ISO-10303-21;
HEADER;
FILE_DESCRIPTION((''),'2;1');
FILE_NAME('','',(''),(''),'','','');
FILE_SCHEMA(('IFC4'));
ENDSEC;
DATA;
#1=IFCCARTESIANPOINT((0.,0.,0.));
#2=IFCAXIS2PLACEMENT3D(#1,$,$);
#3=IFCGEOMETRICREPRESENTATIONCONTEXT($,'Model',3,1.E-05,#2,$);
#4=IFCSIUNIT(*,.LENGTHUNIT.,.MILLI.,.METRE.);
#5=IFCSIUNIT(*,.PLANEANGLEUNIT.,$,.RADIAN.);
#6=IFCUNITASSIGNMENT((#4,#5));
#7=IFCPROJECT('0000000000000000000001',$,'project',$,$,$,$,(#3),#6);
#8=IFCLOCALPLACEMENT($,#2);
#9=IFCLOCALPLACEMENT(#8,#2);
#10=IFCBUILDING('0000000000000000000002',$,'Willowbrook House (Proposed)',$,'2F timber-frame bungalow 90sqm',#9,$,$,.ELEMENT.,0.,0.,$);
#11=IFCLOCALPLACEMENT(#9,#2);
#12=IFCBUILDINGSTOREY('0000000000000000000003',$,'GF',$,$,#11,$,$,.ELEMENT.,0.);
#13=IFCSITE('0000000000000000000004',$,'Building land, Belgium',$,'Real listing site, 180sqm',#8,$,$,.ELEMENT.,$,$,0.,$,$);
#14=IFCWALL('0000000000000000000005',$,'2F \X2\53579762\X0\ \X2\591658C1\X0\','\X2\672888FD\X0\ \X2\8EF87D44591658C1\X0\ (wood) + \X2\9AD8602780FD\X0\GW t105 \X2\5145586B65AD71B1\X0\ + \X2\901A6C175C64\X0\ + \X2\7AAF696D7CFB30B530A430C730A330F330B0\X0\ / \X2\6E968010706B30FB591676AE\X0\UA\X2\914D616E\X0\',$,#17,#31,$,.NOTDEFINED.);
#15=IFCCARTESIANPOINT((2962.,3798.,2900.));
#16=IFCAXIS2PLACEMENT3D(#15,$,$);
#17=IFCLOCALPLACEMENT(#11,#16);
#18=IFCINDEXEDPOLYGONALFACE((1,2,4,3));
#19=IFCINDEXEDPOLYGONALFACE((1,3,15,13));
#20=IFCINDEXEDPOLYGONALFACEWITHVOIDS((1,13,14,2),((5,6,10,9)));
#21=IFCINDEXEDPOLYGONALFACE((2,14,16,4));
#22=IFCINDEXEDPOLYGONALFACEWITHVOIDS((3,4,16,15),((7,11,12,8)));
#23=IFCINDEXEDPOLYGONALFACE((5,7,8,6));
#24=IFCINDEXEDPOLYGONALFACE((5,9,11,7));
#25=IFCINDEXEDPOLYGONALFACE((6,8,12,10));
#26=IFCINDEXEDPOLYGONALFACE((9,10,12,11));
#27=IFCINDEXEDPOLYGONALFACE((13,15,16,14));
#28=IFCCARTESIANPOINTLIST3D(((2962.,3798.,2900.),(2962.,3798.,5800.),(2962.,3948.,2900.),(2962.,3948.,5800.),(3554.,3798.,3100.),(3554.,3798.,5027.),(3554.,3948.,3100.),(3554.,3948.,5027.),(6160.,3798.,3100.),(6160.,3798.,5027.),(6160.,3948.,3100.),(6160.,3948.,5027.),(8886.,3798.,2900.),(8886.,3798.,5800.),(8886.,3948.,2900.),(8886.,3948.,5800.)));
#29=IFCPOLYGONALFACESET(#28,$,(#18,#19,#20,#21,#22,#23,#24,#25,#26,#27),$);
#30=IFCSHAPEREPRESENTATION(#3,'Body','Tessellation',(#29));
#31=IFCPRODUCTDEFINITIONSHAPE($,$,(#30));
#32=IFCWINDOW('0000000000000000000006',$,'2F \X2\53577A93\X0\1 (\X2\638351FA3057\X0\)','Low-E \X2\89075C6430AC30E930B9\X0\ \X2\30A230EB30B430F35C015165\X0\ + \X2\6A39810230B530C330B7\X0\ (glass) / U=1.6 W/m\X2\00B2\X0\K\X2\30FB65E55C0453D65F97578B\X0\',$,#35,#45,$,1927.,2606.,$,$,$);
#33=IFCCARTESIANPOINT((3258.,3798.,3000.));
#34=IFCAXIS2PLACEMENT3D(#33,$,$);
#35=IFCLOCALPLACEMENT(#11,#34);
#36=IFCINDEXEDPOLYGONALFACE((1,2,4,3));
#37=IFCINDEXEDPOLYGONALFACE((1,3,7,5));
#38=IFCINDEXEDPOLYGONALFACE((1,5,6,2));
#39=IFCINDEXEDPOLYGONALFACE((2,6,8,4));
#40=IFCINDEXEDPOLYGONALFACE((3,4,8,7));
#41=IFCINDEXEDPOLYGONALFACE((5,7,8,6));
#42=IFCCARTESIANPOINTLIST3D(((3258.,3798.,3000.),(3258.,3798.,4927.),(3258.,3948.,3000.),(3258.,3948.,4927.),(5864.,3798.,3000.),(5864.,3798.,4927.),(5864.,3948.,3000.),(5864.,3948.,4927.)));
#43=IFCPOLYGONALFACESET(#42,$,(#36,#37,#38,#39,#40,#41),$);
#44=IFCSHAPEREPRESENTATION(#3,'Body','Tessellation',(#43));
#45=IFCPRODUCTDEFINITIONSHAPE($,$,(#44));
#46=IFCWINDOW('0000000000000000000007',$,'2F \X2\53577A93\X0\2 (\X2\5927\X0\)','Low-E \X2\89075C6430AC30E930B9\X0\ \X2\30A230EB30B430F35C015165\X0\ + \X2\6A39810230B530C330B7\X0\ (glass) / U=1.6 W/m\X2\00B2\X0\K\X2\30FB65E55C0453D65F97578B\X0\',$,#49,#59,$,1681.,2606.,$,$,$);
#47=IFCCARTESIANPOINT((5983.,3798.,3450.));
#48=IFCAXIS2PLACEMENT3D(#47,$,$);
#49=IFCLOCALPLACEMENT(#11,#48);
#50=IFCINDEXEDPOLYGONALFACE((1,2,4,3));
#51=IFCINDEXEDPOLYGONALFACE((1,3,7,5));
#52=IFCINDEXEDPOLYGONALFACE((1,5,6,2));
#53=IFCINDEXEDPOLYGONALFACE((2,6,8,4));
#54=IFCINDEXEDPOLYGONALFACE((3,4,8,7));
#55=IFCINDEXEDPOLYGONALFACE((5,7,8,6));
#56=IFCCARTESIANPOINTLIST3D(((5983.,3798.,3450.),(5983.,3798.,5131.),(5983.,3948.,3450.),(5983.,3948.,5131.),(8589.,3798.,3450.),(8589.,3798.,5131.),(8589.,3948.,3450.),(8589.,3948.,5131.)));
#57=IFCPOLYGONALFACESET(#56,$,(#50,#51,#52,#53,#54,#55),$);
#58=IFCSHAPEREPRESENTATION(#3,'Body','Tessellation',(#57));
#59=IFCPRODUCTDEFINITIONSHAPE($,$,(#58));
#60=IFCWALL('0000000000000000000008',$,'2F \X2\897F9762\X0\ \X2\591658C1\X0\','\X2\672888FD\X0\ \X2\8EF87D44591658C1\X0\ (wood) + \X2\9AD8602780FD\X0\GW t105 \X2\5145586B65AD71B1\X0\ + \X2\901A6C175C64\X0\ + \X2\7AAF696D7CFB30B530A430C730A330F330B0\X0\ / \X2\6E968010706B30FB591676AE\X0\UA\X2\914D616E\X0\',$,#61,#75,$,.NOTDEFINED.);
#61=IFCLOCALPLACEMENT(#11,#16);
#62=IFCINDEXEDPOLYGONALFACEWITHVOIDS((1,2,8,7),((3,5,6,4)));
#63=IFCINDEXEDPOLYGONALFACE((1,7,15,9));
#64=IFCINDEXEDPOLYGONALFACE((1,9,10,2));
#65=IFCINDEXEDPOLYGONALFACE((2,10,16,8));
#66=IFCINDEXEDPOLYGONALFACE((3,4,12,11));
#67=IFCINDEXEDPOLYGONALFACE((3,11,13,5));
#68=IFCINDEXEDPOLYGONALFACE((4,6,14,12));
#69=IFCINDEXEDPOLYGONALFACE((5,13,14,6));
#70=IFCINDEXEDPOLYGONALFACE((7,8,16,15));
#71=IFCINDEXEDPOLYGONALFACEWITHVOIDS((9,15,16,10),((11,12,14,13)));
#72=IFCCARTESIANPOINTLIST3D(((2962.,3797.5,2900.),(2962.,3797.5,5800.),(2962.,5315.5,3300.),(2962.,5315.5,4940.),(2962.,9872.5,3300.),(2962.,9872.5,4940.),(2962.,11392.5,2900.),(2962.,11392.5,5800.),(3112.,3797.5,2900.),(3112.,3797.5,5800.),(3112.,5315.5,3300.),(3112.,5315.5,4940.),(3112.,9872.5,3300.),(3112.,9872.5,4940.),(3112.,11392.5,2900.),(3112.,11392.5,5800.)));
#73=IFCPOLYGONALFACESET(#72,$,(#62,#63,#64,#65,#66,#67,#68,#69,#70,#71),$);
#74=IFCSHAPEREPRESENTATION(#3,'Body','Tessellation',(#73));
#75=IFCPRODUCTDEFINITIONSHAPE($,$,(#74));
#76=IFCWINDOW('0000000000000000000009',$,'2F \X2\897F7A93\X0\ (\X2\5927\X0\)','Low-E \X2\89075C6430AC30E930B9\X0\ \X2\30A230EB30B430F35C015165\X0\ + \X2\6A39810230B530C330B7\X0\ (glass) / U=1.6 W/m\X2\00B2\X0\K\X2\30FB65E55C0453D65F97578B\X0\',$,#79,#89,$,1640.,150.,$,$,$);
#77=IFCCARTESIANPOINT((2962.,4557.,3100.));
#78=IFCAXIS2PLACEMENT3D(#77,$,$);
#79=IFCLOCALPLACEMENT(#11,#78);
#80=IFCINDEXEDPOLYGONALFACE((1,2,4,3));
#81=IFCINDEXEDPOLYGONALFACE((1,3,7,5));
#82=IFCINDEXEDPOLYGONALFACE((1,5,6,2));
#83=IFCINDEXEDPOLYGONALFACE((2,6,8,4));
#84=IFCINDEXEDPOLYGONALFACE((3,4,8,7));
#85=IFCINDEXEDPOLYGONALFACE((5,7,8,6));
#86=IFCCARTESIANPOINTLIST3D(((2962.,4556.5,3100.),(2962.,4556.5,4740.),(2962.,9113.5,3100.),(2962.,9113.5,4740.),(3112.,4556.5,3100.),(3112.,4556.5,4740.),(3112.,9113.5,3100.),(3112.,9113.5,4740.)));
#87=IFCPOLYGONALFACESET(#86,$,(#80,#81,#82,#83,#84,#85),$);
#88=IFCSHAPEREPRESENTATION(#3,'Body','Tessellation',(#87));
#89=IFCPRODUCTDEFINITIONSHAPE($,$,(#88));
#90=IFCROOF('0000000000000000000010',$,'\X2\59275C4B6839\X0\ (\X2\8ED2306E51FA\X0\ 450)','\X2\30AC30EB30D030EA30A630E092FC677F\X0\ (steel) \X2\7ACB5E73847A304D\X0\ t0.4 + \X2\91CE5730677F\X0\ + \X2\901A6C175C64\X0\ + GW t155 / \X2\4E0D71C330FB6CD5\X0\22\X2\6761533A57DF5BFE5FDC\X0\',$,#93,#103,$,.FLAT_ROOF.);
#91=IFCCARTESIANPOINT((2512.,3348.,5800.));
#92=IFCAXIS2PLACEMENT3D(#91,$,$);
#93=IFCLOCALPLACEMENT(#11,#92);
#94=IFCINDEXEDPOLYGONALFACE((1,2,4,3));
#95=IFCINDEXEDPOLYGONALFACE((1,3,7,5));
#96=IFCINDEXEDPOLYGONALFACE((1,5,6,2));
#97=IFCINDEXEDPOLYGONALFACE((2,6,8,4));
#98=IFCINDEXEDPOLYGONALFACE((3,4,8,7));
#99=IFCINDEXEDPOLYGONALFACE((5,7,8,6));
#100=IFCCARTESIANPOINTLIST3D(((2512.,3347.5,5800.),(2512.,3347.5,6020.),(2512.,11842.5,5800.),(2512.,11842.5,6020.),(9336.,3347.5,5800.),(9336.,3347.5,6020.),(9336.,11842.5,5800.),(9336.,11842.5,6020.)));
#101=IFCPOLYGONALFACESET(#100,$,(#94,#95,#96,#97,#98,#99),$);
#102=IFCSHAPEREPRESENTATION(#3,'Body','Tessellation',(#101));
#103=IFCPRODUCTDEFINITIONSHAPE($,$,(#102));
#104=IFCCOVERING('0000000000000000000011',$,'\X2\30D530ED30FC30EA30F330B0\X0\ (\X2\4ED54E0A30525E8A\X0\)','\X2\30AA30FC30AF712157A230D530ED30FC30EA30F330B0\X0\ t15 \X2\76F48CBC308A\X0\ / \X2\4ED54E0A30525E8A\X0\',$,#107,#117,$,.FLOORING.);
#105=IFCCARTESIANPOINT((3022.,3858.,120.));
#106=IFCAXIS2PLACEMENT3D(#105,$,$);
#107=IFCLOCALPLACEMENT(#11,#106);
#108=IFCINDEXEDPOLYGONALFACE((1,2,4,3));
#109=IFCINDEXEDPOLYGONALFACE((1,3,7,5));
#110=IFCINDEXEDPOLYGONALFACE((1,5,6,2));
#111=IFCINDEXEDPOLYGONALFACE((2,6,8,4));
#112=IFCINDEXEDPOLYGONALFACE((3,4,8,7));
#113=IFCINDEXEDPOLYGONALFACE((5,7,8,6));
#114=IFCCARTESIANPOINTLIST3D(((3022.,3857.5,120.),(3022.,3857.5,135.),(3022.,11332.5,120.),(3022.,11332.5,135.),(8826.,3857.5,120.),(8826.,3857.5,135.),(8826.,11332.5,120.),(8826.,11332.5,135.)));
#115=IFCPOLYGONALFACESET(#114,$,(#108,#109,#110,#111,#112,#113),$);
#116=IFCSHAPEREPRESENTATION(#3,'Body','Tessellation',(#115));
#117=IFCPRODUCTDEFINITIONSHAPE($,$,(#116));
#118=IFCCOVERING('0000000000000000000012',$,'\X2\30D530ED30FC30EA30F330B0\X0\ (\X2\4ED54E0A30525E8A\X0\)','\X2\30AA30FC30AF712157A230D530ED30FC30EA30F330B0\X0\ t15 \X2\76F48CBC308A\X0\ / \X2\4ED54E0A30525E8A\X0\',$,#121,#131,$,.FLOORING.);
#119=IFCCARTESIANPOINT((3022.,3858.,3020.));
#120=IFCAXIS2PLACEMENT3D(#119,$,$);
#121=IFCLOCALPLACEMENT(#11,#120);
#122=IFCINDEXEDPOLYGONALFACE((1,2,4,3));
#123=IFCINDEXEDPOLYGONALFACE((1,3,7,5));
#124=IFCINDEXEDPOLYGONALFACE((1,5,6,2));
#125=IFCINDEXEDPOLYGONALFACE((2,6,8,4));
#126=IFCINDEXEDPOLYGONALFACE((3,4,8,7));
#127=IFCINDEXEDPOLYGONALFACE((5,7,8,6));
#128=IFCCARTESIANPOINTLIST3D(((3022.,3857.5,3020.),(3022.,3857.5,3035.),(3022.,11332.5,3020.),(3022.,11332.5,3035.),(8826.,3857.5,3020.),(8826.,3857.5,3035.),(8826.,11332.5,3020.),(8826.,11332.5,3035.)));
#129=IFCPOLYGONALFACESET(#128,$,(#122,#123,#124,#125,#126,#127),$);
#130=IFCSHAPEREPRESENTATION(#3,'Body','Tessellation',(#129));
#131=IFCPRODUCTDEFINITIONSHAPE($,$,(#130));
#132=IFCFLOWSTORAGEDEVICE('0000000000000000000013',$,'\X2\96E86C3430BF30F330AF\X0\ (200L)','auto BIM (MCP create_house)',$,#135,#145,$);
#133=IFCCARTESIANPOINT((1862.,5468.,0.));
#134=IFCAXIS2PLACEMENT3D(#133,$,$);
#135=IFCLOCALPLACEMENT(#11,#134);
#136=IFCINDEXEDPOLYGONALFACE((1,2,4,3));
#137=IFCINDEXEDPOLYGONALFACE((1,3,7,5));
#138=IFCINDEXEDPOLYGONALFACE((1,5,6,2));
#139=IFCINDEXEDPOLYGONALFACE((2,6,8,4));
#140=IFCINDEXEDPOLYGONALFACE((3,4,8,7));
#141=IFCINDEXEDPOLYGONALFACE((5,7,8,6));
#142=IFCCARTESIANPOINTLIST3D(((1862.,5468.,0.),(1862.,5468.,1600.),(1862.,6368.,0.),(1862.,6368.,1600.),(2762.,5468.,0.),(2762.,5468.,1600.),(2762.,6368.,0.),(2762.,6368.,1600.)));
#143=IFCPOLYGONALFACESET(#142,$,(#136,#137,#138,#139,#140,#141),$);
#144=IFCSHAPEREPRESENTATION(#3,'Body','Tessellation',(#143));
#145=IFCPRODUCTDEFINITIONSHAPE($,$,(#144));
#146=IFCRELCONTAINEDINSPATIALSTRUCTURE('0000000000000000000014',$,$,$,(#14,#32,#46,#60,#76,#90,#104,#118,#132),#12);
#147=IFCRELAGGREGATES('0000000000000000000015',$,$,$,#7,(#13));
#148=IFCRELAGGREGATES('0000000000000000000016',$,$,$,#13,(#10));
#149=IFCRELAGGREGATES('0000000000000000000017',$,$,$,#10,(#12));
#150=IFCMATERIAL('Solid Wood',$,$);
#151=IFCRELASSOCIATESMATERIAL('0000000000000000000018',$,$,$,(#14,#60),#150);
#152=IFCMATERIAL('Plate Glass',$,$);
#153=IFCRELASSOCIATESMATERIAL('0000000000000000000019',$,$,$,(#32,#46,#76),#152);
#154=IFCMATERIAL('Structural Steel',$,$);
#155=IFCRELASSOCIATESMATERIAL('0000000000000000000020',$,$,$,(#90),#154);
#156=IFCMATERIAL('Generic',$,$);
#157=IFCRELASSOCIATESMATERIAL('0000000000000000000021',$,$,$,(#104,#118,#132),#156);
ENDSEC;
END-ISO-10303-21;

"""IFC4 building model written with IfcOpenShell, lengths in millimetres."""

from ifc_helpers import new_model, si_unit, frame, frame_2d, origin, place, context, project, spatial, rectangle, extrude, material, element, fill, save


model = new_model("IFC4")

# Units and contexts
model_context = context("Model", 3, precision=1e-05, world=origin())
ifc_project = project(units=[si_unit("LENGTHUNIT", "METRE", prefix="MILLI"), si_unit("PLANEANGLEUNIT", "RADIAN")], contexts=[model_context])

# Site, building, storey
site_placement = place(None, origin())
site = spatial("IfcSite", under=ifc_project, at=site_placement, Name="Building land, Belgium", ObjectType="Real listing site, 180sqm", CompositionType="ELEMENT", RefElevation=0.0)
building_placement = place(site_placement, origin())
building = spatial("IfcBuilding", under=site, at=building_placement, Name="Willowbrook House (Proposed)", ObjectType="2F timber-frame bungalow 90sqm", CompositionType="ELEMENT", ElevationOfRefHeight=0.0, ElevationOfTerrain=0.0)
storey_placement = place(building_placement, origin())
storey = spatial("IfcBuildingStorey", under=building, at=storey_placement, Name="GF", CompositionType="ELEMENT", Elevation=0.0)

# Shared definitions
ifc_material_1 = material(Name="Solid Wood")

# Shared definitions
ifc_material_2 = material(Name="Plate Glass")

# Wall, openings, windows
wall_1_placement = place(storey_placement, frame((2962.0, 3798.0, 2900.0)))
wall_1 = element("IfcWall", 1, at=wall_1_placement, inside=storey, material=ifc_material_1, Name="2F 南面 外壁", Description="木製 軸組外壁 (wood) + 高性能GW t105 充填断熱 + 通気層 + 窯業系サイディング / 準耐火・外皮UA配慮", PredefinedType="NOTDEFINED", context=model_context, shape_type="SweptSolid", body=[
    extrude(rectangle(XDim=5924.0, YDim=150.0, at=frame_2d((2962.0, 75.0))), frame((2962.0, 3798.0, 2900.0)), (0.0, 0.0, 1.0), 2900.0),
])
opening_1_placement = place(storey_placement, frame((3258.0, 3798.0, 3000.0)))
opening_1 = element("IfcOpeningElement", 2, at=opening_1_placement, cuts=wall_1, PredefinedType="NOTDEFINED", context=model_context, shape_type="SweptSolid", body=[
    extrude(rectangle(XDim=2606.0, YDim=150.0, at=frame_2d((1303.0, 75.0))), frame((3258.0, 3798.0, 3000.0)), (0.0, 0.0, 1.0), 1927.0),
])
opening_2_placement = place(storey_placement, frame((5983.0, 3798.0, 3450.0)))
opening_2 = element("IfcOpeningElement", 3, at=opening_2_placement, cuts=wall_1, PredefinedType="NOTDEFINED", context=model_context, shape_type="SweptSolid", body=[
    extrude(rectangle(XDim=2606.0, YDim=150.0, at=frame_2d((1303.0, 75.0))), frame((5983.0, 3798.0, 3450.0)), (0.0, 0.0, 1.0), 1681.0),
])
window_1_placement = place(storey_placement, frame((3258.0, 3798.0, 3000.0)))
window_1 = element("IfcWindow", 4, at=window_1_placement, inside=storey, material=ifc_material_2, Name="2F 南窓1 (掃出し)", Description="Low-E 複層ガラス アルゴン封入 + 樹脂サッシ (glass) / U=1.6 W/m²K・日射取得型", OverallHeight=1927.0, OverallWidth=2606.0, context=model_context, shape_type="SweptSolid", body=[
    extrude(rectangle(XDim=2606.0, YDim=150.0, at=frame_2d((1303.0, 75.0))), frame((3258.0, 3798.0, 3000.0)), (0.0, 0.0, 1.0), 1927.0),
])
fill(opening_1, window_1)
window_2_placement = place(storey_placement, frame((5983.0, 3798.0, 3450.0)))
window_2 = element("IfcWindow", 5, at=window_2_placement, inside=storey, material=ifc_material_2, Name="2F 南窓2 (大)", Description="Low-E 複層ガラス アルゴン封入 + 樹脂サッシ (glass) / U=1.6 W/m²K・日射取得型", OverallHeight=1681.0, OverallWidth=2606.0, context=model_context, shape_type="SweptSolid", body=[
    extrude(rectangle(XDim=2606.0, YDim=150.0, at=frame_2d((1303.0, 75.0))), frame((5983.0, 3798.0, 3450.0)), (0.0, 0.0, 1.0), 1681.0),
])
fill(opening_2, window_2)

# Wall, opening, window
wall_2_placement = place(storey_placement, frame((2962.0, 3798.0, 2900.0)))
wall_2 = element("IfcWall", 6, at=wall_2_placement, inside=storey, material=ifc_material_1, Name="2F 西面 外壁", Description="木製 軸組外壁 (wood) + 高性能GW t105 充填断熱 + 通気層 + 窯業系サイディング / 準耐火・外皮UA配慮", PredefinedType="NOTDEFINED", context=model_context, shape_type="SweptSolid", body=[
    extrude(rectangle(XDim=150.0, YDim=7595.0, at=frame_2d((75.0, 3797.0))), frame((2962.0, 3798.0, 2900.0)), (0.0, 0.0, 1.0), 2900.0),
])
opening_3_placement = place(storey_placement, frame((2962.0, 4557.0, 3100.0)))
opening_3 = element("IfcOpeningElement", 7, at=opening_3_placement, cuts=wall_2, PredefinedType="NOTDEFINED", context=model_context, shape_type="SweptSolid", body=[
    extrude(rectangle(XDim=150.0, YDim=4557.0, at=frame_2d((75.0, 2278.0))), frame((2962.0, 4557.0, 3100.0)), (0.0, 0.0, 1.0), 1640.0),
])
window_3_placement = place(storey_placement, frame((2962.0, 4557.0, 3100.0)))
window_3 = element("IfcWindow", 8, at=window_3_placement, inside=storey, material=ifc_material_2, Name="2F 西窓 (大)", Description="Low-E 複層ガラス アルゴン封入 + 樹脂サッシ (glass) / U=1.6 W/m²K・日射取得型", OverallHeight=1640.0, OverallWidth=150.0, context=model_context, shape_type="SweptSolid", body=[
    extrude(rectangle(XDim=150.0, YDim=4557.0, at=frame_2d((75.0, 2278.0))), frame((2962.0, 4557.0, 3100.0)), (0.0, 0.0, 1.0), 1640.0),
])
fill(opening_3, window_3)

# Roof
ifc_material_3 = material(Name="Structural Steel")
roof_placement = place(storey_placement, frame((2512.0, 3348.0, 5800.0)))
element("IfcRoof", 9, at=roof_placement, inside=storey, material=ifc_material_3, Name="大屋根 (軒の出 450)", Description="ガルバリウム鋼板 (steel) 立平葺き t0.4 + 野地板 + 通気層 + GW t155 / 不燃・法22条区域対応", PredefinedType="FLAT_ROOF", context=model_context, shape_type="SweptSolid", body=[
    extrude(rectangle(XDim=6824.0, YDim=8495.0, at=frame_2d((3412.0, 4247.0))), frame((2512.0, 3348.0, 5800.0)), (0.0, 0.0, 1.0), 220.0),
])

# Coverings
ifc_material_4 = material(Name="Generic")
covering_1_placement = place(storey_placement, frame((3022.0, 3858.0, 120.0)))
element("IfcCovering", 10, at=covering_1_placement, inside=storey, material=ifc_material_4, Name="フローリング (仕上げ床)", Description="オーク無垢フローリング t15 直貼り / 仕上げ床", PredefinedType="FLOORING", context=model_context, shape_type="SweptSolid", body=[
    extrude(rectangle(XDim=5804.0, YDim=7475.0, at=frame_2d((2902.0, 3737.0))), frame((3022.0, 3858.0, 120.0)), (0.0, 0.0, 1.0), 15.0),
])
covering_2_placement = place(storey_placement, frame((3022.0, 3858.0, 3020.0)))
element("IfcCovering", 11, at=covering_2_placement, inside=storey, material=ifc_material_4, Name="フローリング (仕上げ床)", Description="オーク無垢フローリング t15 直貼り / 仕上げ床", PredefinedType="FLOORING", context=model_context, shape_type="SweptSolid", body=[
    extrude(rectangle(XDim=5804.0, YDim=7475.0, at=frame_2d((2902.0, 3737.0))), frame((3022.0, 3858.0, 3020.0)), (0.0, 0.0, 1.0), 15.0),
])

# Flow storage device
flow_storage_device_placement = place(storey_placement, frame((1862.0, 5468.0, 0.0)))
element("IfcFlowStorageDevice", 12, at=flow_storage_device_placement, inside=storey, material=ifc_material_4, Name="雨水タンク (200L)", Description="auto BIM (MCP create_house)", context=model_context, shape_type="SweptSolid", body=[
    extrude(rectangle(XDim=900.0, YDim=900.0, at=frame_2d((450.0, 450.0))), frame((1862.0, 5468.0, 0.0)), (0.0, 0.0, 1.0), 1600.0),
])

save(model, "model.ifc")
